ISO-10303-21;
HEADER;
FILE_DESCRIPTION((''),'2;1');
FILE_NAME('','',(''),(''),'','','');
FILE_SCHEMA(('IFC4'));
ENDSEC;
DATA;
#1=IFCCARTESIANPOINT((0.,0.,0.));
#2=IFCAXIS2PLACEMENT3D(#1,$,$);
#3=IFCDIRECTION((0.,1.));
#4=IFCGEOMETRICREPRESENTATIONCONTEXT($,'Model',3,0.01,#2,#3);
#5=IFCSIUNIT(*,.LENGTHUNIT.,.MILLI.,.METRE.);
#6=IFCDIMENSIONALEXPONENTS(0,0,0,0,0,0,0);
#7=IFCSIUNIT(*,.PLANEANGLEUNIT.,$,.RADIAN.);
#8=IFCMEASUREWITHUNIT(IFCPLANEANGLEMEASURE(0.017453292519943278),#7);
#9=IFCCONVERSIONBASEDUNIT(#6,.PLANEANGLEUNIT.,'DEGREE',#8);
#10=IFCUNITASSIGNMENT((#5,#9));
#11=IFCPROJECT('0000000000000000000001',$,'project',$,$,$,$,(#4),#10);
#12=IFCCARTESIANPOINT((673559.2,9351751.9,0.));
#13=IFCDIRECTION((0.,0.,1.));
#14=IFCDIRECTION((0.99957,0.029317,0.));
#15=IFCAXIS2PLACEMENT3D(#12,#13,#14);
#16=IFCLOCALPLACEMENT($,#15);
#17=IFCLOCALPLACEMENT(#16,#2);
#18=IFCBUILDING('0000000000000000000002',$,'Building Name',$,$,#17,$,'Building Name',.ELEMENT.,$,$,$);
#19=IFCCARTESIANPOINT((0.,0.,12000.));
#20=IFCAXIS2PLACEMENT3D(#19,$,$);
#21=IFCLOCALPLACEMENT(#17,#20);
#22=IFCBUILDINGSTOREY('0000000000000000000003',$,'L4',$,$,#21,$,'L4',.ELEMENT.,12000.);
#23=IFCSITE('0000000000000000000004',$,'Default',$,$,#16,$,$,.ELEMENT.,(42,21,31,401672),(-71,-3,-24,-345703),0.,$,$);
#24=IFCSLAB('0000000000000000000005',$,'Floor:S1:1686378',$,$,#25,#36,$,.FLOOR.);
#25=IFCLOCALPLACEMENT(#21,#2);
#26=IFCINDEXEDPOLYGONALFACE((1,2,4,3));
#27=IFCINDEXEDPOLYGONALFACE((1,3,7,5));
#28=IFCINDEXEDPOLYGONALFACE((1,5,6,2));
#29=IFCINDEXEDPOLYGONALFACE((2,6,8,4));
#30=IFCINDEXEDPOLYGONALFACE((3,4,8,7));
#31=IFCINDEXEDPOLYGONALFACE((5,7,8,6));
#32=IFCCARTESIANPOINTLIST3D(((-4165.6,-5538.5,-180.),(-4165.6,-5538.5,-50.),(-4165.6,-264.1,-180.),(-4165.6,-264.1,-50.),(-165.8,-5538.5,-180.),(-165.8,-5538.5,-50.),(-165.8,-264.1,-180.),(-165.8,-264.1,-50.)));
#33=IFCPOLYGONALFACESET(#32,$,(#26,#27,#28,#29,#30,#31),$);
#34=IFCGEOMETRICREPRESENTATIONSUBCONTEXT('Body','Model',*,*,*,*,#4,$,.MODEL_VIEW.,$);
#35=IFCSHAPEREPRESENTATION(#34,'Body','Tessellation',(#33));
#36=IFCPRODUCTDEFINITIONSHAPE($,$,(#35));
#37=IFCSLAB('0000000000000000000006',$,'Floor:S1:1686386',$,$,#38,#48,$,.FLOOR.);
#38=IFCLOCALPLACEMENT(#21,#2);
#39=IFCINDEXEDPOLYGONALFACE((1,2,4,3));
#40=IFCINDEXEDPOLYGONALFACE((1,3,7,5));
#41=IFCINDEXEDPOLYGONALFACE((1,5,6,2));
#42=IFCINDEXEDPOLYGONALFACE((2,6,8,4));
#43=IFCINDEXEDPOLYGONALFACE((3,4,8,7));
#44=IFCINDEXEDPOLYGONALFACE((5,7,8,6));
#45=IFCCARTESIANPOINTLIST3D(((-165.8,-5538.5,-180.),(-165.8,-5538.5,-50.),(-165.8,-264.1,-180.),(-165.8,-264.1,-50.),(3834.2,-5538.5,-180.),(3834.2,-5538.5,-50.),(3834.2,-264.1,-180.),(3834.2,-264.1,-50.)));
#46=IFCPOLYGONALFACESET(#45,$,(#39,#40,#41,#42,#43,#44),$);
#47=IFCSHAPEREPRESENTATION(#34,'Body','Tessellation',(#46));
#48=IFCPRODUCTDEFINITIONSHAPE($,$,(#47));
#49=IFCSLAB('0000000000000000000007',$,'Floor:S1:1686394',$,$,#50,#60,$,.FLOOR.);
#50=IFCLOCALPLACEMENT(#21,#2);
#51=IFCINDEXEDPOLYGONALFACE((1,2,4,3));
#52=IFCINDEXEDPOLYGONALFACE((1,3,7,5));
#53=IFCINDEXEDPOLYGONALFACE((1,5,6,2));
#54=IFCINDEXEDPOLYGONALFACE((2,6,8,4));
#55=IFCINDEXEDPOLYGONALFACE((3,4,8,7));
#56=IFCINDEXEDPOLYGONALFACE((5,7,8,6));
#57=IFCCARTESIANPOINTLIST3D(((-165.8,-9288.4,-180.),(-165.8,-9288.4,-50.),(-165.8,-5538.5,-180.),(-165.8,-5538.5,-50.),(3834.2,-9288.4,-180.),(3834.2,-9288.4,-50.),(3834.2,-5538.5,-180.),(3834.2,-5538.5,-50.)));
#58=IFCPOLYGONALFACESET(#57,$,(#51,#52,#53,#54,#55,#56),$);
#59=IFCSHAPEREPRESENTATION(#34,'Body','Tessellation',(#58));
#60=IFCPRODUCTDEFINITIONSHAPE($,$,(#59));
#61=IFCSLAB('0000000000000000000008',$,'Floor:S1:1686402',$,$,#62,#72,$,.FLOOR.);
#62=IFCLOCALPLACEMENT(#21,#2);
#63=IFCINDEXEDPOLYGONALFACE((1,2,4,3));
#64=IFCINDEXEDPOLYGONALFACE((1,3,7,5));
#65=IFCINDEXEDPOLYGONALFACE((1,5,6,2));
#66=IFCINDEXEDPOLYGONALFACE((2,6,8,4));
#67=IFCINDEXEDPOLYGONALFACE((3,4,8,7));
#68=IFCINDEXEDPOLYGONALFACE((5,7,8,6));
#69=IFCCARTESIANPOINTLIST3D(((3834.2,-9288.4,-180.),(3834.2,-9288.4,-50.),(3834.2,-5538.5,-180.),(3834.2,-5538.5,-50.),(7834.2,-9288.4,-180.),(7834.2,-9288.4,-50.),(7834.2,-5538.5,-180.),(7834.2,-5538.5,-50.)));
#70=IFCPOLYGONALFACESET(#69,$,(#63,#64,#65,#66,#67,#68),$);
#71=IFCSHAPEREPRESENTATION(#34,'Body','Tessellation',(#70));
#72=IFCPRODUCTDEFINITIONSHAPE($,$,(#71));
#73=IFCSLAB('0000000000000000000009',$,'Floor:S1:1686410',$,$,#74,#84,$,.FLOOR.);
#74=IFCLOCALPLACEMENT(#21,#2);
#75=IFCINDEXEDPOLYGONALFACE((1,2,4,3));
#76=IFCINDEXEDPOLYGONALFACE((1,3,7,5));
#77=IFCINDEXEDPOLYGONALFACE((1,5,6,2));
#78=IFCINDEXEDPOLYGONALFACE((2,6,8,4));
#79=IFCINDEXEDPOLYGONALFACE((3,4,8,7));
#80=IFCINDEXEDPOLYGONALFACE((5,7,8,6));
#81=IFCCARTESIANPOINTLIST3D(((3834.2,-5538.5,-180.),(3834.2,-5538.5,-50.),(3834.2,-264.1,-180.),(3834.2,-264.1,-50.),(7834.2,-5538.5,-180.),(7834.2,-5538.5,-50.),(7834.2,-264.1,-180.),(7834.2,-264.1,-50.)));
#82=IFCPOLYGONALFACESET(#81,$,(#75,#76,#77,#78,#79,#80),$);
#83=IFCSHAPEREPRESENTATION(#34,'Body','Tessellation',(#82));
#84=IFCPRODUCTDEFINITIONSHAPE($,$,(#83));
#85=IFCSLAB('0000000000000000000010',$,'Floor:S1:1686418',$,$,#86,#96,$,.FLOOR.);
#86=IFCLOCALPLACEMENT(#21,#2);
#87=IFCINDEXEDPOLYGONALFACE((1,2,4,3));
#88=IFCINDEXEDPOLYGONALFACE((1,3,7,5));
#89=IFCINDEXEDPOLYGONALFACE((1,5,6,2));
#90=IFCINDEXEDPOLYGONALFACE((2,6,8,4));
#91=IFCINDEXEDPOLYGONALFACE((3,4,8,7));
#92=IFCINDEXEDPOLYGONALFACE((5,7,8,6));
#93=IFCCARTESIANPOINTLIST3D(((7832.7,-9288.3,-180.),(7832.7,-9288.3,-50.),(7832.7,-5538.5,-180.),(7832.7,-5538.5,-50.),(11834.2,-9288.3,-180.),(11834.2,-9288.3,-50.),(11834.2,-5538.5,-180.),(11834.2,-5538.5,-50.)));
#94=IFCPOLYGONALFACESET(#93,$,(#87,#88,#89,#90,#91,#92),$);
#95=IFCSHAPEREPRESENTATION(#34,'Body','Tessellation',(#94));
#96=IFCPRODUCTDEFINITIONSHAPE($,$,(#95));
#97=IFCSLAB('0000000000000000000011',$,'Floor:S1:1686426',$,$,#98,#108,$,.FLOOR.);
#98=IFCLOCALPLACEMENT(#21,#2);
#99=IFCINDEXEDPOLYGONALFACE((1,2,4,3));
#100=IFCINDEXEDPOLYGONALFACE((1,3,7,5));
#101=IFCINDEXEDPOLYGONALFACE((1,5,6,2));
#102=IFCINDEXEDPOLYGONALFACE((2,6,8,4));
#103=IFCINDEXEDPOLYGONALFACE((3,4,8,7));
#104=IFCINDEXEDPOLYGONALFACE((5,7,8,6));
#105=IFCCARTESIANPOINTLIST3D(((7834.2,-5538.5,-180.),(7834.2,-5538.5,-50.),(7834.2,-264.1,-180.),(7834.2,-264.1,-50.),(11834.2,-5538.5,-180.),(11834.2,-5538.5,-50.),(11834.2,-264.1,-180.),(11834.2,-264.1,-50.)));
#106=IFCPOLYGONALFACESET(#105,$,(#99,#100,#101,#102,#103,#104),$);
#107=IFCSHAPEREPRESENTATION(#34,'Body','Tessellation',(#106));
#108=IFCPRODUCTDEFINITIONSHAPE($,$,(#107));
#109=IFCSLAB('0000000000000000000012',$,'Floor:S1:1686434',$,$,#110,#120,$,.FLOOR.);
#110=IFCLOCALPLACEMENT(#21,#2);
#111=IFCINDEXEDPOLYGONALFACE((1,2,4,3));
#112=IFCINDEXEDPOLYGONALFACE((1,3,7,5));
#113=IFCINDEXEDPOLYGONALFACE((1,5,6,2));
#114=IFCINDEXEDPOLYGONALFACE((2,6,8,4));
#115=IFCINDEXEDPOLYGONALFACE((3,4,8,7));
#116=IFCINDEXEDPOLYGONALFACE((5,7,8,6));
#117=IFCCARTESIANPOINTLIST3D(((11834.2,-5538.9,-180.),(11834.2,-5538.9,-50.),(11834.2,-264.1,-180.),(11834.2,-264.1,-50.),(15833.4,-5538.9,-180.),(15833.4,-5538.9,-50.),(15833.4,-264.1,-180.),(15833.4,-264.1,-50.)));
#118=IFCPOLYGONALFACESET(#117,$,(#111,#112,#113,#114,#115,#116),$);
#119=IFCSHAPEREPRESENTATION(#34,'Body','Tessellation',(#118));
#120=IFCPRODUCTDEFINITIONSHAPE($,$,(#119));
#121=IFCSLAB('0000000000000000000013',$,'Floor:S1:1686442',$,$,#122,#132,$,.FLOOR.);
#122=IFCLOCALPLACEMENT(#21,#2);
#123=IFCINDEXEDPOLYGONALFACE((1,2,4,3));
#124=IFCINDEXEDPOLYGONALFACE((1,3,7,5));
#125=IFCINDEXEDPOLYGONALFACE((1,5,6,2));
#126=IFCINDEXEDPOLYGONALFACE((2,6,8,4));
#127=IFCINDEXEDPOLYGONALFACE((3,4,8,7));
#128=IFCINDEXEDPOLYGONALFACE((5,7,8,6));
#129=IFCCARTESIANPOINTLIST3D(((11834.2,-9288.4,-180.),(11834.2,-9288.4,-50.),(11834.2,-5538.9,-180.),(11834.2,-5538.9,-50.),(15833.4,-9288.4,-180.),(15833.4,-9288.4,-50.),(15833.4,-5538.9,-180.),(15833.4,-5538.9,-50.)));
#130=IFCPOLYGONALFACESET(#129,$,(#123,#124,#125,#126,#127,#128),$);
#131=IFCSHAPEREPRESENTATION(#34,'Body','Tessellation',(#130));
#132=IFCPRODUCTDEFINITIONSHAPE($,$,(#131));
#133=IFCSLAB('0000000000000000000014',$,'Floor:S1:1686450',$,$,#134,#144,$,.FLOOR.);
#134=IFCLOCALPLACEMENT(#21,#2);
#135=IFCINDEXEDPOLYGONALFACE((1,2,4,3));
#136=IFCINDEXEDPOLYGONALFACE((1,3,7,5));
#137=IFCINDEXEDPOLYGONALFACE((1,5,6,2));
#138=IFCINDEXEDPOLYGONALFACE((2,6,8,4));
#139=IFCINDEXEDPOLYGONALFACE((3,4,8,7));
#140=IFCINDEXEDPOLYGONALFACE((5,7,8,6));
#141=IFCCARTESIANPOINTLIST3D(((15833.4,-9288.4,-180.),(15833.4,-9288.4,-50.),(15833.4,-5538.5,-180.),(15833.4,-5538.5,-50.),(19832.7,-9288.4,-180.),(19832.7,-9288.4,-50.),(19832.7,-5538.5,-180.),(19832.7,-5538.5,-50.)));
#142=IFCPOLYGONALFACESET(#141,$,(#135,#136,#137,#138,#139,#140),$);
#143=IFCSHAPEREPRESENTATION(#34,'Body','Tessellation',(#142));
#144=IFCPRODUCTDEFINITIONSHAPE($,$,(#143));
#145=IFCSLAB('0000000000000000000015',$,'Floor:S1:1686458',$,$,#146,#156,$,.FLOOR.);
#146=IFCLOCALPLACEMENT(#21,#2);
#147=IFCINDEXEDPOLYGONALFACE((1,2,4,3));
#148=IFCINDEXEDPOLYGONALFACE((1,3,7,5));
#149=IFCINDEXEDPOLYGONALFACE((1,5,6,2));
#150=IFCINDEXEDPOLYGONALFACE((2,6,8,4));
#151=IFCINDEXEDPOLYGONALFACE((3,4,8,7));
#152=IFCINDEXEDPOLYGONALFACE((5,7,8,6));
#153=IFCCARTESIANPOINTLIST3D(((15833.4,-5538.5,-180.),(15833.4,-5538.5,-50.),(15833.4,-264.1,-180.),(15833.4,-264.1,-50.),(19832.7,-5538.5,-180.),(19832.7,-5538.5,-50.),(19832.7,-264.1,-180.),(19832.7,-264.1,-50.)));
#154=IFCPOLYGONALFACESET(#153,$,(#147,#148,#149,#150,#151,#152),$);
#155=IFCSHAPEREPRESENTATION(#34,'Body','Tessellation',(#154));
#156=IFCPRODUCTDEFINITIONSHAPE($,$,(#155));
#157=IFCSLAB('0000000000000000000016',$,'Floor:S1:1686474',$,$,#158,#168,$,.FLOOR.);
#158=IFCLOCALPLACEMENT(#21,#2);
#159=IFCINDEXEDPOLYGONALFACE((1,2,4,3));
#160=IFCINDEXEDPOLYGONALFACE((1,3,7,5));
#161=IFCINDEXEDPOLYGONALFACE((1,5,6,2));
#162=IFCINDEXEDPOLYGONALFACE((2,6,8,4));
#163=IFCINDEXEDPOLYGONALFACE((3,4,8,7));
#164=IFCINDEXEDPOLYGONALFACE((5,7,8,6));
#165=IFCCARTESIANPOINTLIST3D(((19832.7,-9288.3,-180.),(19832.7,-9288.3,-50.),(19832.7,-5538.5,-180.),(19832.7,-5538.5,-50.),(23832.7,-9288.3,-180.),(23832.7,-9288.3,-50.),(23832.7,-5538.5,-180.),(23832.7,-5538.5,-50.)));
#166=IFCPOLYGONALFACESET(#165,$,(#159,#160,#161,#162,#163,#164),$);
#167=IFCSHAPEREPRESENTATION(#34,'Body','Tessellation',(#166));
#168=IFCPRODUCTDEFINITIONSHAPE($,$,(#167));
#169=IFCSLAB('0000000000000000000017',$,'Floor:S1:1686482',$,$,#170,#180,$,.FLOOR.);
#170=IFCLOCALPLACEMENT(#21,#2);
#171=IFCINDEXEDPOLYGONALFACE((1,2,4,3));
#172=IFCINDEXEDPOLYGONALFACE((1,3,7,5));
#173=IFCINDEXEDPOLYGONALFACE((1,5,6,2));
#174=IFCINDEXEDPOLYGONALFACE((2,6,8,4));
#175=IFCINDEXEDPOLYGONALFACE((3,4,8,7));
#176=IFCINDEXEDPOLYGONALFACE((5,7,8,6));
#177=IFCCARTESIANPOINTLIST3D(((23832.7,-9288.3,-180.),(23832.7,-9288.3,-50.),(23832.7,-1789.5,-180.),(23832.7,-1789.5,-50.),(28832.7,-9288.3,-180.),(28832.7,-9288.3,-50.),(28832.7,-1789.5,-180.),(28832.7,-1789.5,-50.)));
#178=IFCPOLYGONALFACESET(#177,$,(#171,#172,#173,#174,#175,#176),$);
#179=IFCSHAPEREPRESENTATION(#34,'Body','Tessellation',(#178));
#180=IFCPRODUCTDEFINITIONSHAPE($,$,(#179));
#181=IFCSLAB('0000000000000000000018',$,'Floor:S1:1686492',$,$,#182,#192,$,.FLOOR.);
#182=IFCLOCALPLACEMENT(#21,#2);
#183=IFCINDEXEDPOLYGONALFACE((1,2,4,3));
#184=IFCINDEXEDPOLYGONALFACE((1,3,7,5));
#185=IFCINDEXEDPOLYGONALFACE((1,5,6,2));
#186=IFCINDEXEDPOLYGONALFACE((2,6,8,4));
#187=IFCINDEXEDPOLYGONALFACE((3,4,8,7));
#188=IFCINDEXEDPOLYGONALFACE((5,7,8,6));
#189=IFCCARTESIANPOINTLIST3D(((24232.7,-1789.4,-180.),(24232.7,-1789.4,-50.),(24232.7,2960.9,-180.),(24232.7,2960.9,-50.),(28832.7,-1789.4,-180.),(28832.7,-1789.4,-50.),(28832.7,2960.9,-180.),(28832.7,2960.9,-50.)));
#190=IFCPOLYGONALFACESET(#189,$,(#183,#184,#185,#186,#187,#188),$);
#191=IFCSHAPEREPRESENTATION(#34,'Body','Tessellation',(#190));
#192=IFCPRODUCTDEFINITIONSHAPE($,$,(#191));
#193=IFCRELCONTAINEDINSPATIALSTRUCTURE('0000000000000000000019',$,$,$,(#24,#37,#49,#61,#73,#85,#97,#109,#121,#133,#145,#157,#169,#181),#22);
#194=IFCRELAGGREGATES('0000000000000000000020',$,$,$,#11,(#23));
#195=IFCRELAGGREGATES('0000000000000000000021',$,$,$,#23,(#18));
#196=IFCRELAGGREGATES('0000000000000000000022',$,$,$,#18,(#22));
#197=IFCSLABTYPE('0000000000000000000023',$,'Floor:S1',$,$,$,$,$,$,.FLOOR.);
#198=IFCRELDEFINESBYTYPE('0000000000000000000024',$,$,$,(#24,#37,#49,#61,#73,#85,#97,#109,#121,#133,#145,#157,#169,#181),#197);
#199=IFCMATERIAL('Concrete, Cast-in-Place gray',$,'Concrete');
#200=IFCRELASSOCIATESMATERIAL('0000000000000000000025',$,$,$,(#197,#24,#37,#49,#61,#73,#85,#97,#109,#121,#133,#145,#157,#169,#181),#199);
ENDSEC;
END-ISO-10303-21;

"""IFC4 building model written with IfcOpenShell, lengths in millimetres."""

from ifc_helpers import new_model, entity, si_unit, converted_unit, direction, frame, origin, place, context, subcontext, project, spatial, indexed_curve, outline, extrude, material, type_object, element, save


model = new_model("IFC4")

# Units and contexts
model_context = context("Model", 3, precision=0.01, world=origin(), true_north=direction((0.0, 1.0)))
body_context = subcontext(model_context, "Body", "Model", "MODEL_VIEW")
ifc_project = project(units=[si_unit("LENGTHUNIT", "METRE", prefix="MILLI"), converted_unit("PLANEANGLEUNIT", "DEGREE", entity("IfcPlaneAngleMeasure", 0.017453292519943278), si_unit("PLANEANGLEUNIT", "RADIAN"), dimensions=[0, 0, 0, 0, 0, 0, 0])], contexts=[model_context])

# Site, building, storey
site_placement = place(None, frame((673559.2, 9351751.9, 0.0), z_axis=(0.0, 0.0, 1.0), x_axis=(0.99957, 0.029317, 0.0)))
site = spatial("IfcSite", under=ifc_project, at=site_placement, Name="Default", CompositionType="ELEMENT", RefLatitude=(42, 21, 31, 401672), RefLongitude=(-71, -3, -24, -345703), RefElevation=0.0)
building_placement = place(site_placement, origin())
building = spatial("IfcBuilding", under=site, at=building_placement, Name="Building Name", LongName="Building Name", CompositionType="ELEMENT")
storey_placement = place(building_placement, frame((0.0, 0.0, 12000.0)))
storey = spatial("IfcBuildingStorey", under=building, at=storey_placement, Name="L4", LongName="L4", CompositionType="ELEMENT", Elevation=12000.0)

# Shared definitions
ifc_material = material(Name="Concrete, Cast-in-Place gray", Category="Concrete")

# Slabs
slab_type_1 = type_object("IfcSlabType", Name="Floor:S1", PredefinedType="FLOOR", material=ifc_material)
slab_1_placement = place(storey_placement, origin())
element("IfcSlab", 1, at=slab_1_placement, inside=storey, type_object=slab_type_1, material=ifc_material, Name="Floor:S1:1686378", PredefinedType="FLOOR", context=body_context, shape_type="SweptSolid", body=[
    extrude(outline(indexed_curve([(-2637.2, -1999.9), (2637.2, -1999.9), (2637.2, 1999.9), (-2637.2, 1999.9), (-2637.2, -1999.9)], self_intersect=False)), frame((-2165.7, -2901.3, -50.0), z_axis=(0.0, 0.0, -1.0), x_axis=(0.0, 1.0, 0.0)), (0.0, 0.0, 1.0), 130.0),
])
slab_2_placement = place(storey_placement, origin())
element("IfcSlab", 2, at=slab_2_placement, inside=storey, type_object=slab_type_1, material=ifc_material, Name="Floor:S1:1686386", PredefinedType="FLOOR", context=body_context, shape_type="SweptSolid", body=[
    extrude(outline(indexed_curve([(-2637.2, -2000.0), (2637.2, -2000.0), (2637.2, 2000.0), (-2637.2, 2000.0), (-2637.2, -2000.0)], self_intersect=False)), frame((1834.2, -2901.3, -50.0), z_axis=(0.0, 0.0, -1.0), x_axis=(0.0, 1.0, 0.0)), (0.0, 0.0, 1.0), 130.0),
])
slab_3_placement = place(storey_placement, origin())
element("IfcSlab", 3, at=slab_3_placement, inside=storey, type_object=slab_type_1, material=ifc_material, Name="Floor:S1:1686394", PredefinedType="FLOOR", context=body_context, shape_type="SweptSolid", body=[
    extrude(outline(indexed_curve([(-1874.9, -2000.0), (1874.9, -2000.0), (1874.9, 2000.0), (-1874.9, 2000.0), (-1874.9, -2000.0)], self_intersect=False)), frame((1834.2, -7413.5, -50.0), z_axis=(0.0, 0.0, -1.0), x_axis=(0.0, 1.0, 0.0)), (0.0, 0.0, 1.0), 130.0),
])
slab_4_placement = place(storey_placement, origin())
element("IfcSlab", 4, at=slab_4_placement, inside=storey, type_object=slab_type_1, material=ifc_material, Name="Floor:S1:1686402", PredefinedType="FLOOR", context=body_context, shape_type="SweptSolid", body=[
    extrude(outline(indexed_curve([(-1874.9, -2000.0), (1874.9, -2000.0), (1874.9, 2000.0), (-1874.9, 2000.0), (-1874.9, -2000.0)], self_intersect=False)), frame((5834.2, -7413.5, -50.0), z_axis=(0.0, 0.0, -1.0), x_axis=(0.0, 1.0, 0.0)), (0.0, 0.0, 1.0), 130.0),
])
slab_5_placement = place(storey_placement, origin())
element("IfcSlab", 5, at=slab_5_placement, inside=storey, type_object=slab_type_1, material=ifc_material, Name="Floor:S1:1686410", PredefinedType="FLOOR", context=body_context, shape_type="SweptSolid", body=[
    extrude(outline(indexed_curve([(-2637.2, -2000.0), (2637.2, -2000.0), (2637.2, 2000.0), (-2637.2, 2000.0), (-2637.2, -2000.0)], self_intersect=False)), frame((5834.2, -2901.3, -50.0), z_axis=(0.0, 0.0, -1.0), x_axis=(0.0, 1.0, 0.0)), (0.0, 0.0, 1.0), 130.0),
])
slab_6_placement = place(storey_placement, origin())
element("IfcSlab", 6, at=slab_6_placement, inside=storey, type_object=slab_type_1, material=ifc_material, Name="Floor:S1:1686418", PredefinedType="FLOOR", context=body_context, shape_type="SweptSolid", body=[
    extrude(outline(indexed_curve([(-1874.9, -2000.7), (1874.9, -2000.7), (1874.9, 2000.7), (-1874.9, 2000.7), (-1874.9, -2000.7)], self_intersect=False)), frame((9833.4, -7413.4, -50.0), z_axis=(0.0, 0.0, -1.0), x_axis=(0.0, 1.0, 0.0)), (0.0, 0.0, 1.0), 130.0),
])
slab_7_placement = place(storey_placement, origin())
element("IfcSlab", 7, at=slab_7_placement, inside=storey, type_object=slab_type_1, material=ifc_material, Name="Floor:S1:1686426", PredefinedType="FLOOR", context=body_context, shape_type="SweptSolid", body=[
    extrude(outline(indexed_curve([(-2637.2, -2000.0), (2637.2, -2000.0), (2637.2, 2000.0), (-2637.2, 2000.0), (-2637.2, -2000.0)], self_intersect=False)), frame((9834.2, -2901.3, -50.0), z_axis=(0.0, 0.0, -1.0), x_axis=(0.0, 1.0, 0.0)), (0.0, 0.0, 1.0), 130.0),
])
slab_8_placement = place(storey_placement, origin())
element("IfcSlab", 8, at=slab_8_placement, inside=storey, type_object=slab_type_1, material=ifc_material, Name="Floor:S1:1686434", PredefinedType="FLOOR", context=body_context, shape_type="SweptSolid", body=[
    extrude(outline(indexed_curve([(-2637.4, -1999.6), (2637.4, -1999.6), (2637.4, 1999.6), (-2637.4, 1999.6), (-2637.4, -1999.6)], self_intersect=False)), frame((13833.8, -2901.5, -50.0), z_axis=(0.0, 0.0, -1.0), x_axis=(0.0, 1.0, 0.0)), (0.0, 0.0, 1.0), 130.0),
])
slab_9_placement = place(storey_placement, origin())
element("IfcSlab", 9, at=slab_9_placement, inside=storey, type_object=slab_type_1, material=ifc_material, Name="Floor:S1:1686442", PredefinedType="FLOOR", context=body_context, shape_type="SweptSolid", body=[
    extrude(outline(indexed_curve([(-1874.7, -1999.6), (1874.7, -1999.6), (1874.7, 1999.6), (-1874.7, 1999.6), (-1874.7, -1999.6)], self_intersect=False)), frame((13833.8, -7413.6, -50.0), z_axis=(0.0, 0.0, -1.0), x_axis=(0.0, 1.0, 0.0)), (0.0, 0.0, 1.0), 130.0),
])
slab_10_placement = place(storey_placement, origin())
element("IfcSlab", 10, at=slab_10_placement, inside=storey, type_object=slab_type_1, material=ifc_material, Name="Floor:S1:1686450", PredefinedType="FLOOR", context=body_context, shape_type="SweptSolid", body=[
    extrude(outline(indexed_curve([(-1874.9, -1999.6), (1874.9, -1999.6), (1874.9, 1999.6), (-1874.9, 1999.6), (-1874.9, -1999.6)], self_intersect=False)), frame((17833.0, -7413.5, -50.0), z_axis=(0.0, 0.0, -1.0), x_axis=(0.0, 1.0, 0.0)), (0.0, 0.0, 1.0), 130.0),
])
slab_11_placement = place(storey_placement, origin())
element("IfcSlab", 11, at=slab_11_placement, inside=storey, type_object=slab_type_1, material=ifc_material, Name="Floor:S1:1686458", PredefinedType="FLOOR", context=body_context, shape_type="SweptSolid", body=[
    extrude(outline(indexed_curve([(-2637.2, -1999.6), (2637.2, -1999.6), (2637.2, 1999.6), (-2637.2, 1999.6), (-2637.2, -1999.6)], self_intersect=False)), frame((17833.0, -2901.3, -50.0), z_axis=(0.0, 0.0, -1.0), x_axis=(0.0, 1.0, 0.0)), (0.0, 0.0, 1.0), 130.0),
])
slab_12_placement = place(storey_placement, origin())
element("IfcSlab", 12, at=slab_12_placement, inside=storey, type_object=slab_type_1, material=ifc_material, Name="Floor:S1:1686474", PredefinedType="FLOOR", context=body_context, shape_type="SweptSolid", body=[
    extrude(outline(indexed_curve([(-1874.9, -2000.0), (1874.9, -2000.0), (1874.9, 2000.0), (-1874.9, 2000.0), (-1874.9, -2000.0)], self_intersect=False)), frame((21832.7, -7413.4, -50.0), z_axis=(0.0, 0.0, -1.0), x_axis=(0.0, 1.0, 0.0)), (0.0, 0.0, 1.0), 130.0),
])
slab_13_placement = place(storey_placement, origin())
element("IfcSlab", 13, at=slab_13_placement, inside=storey, type_object=slab_type_1, material=ifc_material, Name="Floor:S1:1686482", PredefinedType="FLOOR", context=body_context, shape_type="SweptSolid", body=[
    extrude(outline(indexed_curve([(-3749.4, -2500.0), (3749.4, -2500.0), (3749.4, 2500.0), (-3749.4, 2500.0), (-3749.4, -2500.0)], self_intersect=False)), frame((26332.7, -5538.9, -50.0), z_axis=(0.0, 0.0, -1.0), x_axis=(0.0, 1.0, 0.0)), (0.0, 0.0, 1.0), 130.0),
])
slab_14_placement = place(storey_placement, origin())
element("IfcSlab", 14, at=slab_14_placement, inside=storey, type_object=slab_type_1, material=ifc_material, Name="Floor:S1:1686492", PredefinedType="FLOOR", context=body_context, shape_type="SweptSolid", body=[
    extrude(outline(indexed_curve([(-2375.2, -2300.0), (2375.2, -2300.0), (2375.2, 2300.0), (-2375.2, 2300.0), (-2375.2, -2300.0)], self_intersect=False)), frame((26532.7, 585.8, -50.0), z_axis=(0.0, 0.0, -1.0), x_axis=(0.0, 1.0, 0.0)), (0.0, 0.0, 1.0), 130.0),
])

save(model, "model.ifc")
